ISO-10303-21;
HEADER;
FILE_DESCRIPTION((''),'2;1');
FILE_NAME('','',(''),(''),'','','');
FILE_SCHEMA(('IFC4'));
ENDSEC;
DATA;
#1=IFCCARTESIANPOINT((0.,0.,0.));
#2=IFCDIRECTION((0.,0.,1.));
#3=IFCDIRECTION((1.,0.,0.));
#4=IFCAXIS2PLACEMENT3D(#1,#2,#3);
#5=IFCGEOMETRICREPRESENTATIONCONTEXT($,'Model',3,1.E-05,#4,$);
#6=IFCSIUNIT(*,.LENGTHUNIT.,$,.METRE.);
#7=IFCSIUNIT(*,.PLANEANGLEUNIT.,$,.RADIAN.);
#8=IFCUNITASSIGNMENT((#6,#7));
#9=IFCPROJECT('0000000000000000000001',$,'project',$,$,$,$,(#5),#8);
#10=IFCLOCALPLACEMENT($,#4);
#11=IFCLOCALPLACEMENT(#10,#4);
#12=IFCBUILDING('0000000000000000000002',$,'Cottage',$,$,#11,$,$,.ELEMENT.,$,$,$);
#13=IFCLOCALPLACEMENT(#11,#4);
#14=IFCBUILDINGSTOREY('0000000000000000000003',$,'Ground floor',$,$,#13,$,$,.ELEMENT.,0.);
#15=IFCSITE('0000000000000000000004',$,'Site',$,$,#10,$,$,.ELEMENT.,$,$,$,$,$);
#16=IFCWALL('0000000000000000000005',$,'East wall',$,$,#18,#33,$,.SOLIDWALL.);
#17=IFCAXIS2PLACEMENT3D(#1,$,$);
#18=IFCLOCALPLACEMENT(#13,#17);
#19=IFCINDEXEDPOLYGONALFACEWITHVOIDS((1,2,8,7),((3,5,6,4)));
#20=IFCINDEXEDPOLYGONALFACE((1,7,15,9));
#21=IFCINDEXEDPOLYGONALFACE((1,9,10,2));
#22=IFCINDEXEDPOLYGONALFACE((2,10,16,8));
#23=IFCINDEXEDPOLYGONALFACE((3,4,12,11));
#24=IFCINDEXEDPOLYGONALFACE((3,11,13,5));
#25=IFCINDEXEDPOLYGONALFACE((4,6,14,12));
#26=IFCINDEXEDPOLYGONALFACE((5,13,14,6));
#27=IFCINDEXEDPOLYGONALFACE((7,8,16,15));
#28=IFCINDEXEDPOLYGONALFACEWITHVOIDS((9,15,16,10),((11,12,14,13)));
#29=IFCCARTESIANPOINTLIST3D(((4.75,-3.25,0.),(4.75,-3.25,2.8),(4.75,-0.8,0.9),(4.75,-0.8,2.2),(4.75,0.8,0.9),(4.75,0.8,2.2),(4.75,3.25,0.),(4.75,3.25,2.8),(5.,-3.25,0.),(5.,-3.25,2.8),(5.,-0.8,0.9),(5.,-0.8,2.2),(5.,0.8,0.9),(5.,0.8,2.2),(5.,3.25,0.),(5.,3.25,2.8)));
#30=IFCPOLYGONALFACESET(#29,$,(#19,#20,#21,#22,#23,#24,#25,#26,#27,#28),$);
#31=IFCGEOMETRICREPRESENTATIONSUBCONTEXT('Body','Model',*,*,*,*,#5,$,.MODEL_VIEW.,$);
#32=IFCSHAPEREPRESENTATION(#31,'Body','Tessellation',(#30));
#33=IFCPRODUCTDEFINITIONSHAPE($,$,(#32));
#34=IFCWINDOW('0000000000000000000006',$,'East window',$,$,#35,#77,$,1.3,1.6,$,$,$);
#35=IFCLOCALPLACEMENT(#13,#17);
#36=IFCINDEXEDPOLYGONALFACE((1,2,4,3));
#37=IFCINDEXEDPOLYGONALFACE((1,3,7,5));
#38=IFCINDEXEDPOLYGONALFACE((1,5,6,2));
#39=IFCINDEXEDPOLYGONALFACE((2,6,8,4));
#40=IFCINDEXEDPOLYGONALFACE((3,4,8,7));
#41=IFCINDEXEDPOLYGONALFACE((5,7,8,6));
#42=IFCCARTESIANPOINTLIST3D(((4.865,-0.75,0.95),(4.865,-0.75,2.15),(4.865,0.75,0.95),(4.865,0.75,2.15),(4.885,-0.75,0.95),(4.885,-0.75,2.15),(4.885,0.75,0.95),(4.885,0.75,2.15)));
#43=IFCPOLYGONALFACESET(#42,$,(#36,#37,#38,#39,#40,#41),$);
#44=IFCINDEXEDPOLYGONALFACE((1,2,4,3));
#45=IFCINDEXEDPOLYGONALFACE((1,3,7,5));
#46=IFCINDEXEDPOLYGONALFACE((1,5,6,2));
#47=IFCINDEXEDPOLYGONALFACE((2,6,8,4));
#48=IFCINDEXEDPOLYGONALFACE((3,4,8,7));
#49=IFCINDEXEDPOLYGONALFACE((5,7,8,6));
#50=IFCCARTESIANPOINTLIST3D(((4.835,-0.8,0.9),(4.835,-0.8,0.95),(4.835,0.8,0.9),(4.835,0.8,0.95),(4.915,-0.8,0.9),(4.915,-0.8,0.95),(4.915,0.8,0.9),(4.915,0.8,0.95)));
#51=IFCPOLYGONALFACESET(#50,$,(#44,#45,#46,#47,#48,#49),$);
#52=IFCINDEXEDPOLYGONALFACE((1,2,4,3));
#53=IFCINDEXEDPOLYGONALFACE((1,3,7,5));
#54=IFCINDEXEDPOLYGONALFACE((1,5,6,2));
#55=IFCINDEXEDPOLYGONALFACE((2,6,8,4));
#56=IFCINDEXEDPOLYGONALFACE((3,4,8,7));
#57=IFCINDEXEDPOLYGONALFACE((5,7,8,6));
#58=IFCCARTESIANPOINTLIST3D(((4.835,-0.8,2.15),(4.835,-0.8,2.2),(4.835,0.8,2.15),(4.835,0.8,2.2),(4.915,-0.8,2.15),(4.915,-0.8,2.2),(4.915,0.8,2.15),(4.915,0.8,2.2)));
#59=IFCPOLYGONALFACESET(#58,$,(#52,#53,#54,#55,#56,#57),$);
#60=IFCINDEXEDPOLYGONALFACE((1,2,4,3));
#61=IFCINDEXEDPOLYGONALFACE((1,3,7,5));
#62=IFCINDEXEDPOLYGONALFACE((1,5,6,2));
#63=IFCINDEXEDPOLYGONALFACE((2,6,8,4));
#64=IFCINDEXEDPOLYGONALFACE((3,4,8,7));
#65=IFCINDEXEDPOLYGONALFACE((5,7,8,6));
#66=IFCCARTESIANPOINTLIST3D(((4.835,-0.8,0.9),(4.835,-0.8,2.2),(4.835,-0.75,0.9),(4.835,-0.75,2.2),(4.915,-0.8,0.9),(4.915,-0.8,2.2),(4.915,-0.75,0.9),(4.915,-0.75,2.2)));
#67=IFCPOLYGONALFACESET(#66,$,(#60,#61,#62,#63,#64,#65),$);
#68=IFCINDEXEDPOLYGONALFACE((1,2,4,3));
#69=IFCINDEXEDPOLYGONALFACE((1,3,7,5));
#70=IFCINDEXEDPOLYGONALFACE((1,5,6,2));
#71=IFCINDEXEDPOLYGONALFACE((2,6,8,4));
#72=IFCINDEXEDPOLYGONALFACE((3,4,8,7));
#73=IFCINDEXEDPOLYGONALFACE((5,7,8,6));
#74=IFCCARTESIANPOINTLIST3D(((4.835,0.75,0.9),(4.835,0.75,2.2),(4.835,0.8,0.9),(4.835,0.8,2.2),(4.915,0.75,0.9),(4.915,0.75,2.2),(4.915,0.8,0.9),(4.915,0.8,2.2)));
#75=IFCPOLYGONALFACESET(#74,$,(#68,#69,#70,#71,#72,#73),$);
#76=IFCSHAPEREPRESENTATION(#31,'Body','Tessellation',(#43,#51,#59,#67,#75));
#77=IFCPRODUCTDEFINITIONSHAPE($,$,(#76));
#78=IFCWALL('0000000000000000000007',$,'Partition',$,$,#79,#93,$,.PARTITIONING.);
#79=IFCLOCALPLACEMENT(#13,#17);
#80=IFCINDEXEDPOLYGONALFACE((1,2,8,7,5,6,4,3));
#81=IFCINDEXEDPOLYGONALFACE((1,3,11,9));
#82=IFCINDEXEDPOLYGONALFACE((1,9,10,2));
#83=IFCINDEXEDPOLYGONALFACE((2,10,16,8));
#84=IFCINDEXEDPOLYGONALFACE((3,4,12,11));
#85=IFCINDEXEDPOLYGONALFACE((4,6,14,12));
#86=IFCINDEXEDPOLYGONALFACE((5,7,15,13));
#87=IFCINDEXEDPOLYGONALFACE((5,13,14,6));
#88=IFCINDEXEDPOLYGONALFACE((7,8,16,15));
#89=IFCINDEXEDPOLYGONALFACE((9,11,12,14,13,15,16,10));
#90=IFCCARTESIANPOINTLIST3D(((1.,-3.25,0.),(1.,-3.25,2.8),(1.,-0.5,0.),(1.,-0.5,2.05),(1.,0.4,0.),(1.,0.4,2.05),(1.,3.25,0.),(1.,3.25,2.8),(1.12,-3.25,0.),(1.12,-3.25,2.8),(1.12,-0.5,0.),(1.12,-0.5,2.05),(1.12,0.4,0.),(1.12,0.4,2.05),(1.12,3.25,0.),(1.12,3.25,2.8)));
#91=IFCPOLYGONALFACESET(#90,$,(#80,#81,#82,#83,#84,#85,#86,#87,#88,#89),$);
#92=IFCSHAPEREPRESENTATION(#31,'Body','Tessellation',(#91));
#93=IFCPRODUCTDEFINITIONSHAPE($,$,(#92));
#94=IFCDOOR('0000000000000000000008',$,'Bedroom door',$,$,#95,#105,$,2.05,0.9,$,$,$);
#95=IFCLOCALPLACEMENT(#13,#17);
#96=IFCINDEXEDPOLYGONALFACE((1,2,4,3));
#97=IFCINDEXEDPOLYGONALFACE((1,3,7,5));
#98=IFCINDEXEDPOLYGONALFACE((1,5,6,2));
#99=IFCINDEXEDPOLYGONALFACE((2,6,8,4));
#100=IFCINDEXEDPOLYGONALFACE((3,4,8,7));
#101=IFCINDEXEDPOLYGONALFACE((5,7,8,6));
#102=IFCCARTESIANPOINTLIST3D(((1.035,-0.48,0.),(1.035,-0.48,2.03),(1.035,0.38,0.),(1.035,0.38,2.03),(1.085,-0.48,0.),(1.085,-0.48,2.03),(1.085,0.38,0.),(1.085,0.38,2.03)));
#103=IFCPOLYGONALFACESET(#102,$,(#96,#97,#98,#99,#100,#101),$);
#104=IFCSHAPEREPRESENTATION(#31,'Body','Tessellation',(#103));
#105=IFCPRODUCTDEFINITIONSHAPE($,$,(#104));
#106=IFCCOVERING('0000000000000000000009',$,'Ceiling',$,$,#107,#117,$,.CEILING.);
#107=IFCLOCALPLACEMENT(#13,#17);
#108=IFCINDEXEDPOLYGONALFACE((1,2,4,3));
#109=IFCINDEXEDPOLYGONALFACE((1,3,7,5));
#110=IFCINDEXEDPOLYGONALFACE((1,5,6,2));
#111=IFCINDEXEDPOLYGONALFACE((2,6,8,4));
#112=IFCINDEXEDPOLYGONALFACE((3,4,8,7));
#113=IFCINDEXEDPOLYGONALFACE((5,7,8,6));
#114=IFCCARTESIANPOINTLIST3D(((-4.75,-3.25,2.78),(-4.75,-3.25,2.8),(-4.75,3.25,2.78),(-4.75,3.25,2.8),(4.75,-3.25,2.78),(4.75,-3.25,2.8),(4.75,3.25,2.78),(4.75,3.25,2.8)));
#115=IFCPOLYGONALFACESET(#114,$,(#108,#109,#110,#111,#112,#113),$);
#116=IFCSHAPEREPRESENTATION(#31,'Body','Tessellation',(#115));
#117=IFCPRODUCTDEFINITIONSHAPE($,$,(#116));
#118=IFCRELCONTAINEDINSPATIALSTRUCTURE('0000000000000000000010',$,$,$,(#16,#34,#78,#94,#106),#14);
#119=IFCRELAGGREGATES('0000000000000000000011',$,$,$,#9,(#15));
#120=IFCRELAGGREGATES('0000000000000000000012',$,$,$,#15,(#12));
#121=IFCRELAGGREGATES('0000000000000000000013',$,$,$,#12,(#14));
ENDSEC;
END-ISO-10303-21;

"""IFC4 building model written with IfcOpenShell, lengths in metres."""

from ifc_helpers import new_model, si_unit, frame, frame_2d, origin_with_axes, origin_2d, place, context, subcontext, project, spatial, rectangle, extrude, element, fill, save


model = new_model("IFC4")

# Units and contexts
model_context = context("Model", 3, precision=1e-05, world=origin_with_axes())
body_context = subcontext(model_context, "Body", "Model", "MODEL_VIEW")
ifc_project = project(units=[si_unit("LENGTHUNIT", "METRE"), si_unit("PLANEANGLEUNIT", "RADIAN")], contexts=[model_context])

# Site, building, storey
site_placement = place(None, origin_with_axes())
site = spatial("IfcSite", under=ifc_project, at=site_placement, Name="Site", CompositionType="ELEMENT")
building_placement = place(site_placement, origin_with_axes())
building = spatial("IfcBuilding", under=site, at=building_placement, Name="Cottage", CompositionType="ELEMENT")
storey_placement = place(building_placement, origin_with_axes())
storey = spatial("IfcBuildingStorey", under=building, at=storey_placement, Name="Ground floor", CompositionType="ELEMENT", Elevation=0.0)

# Wall, opening, window
wall_1_placement = place(storey_placement, origin_with_axes())
wall_1 = element("IfcWall", 1, at=wall_1_placement, inside=storey, Name="East wall", PredefinedType="SOLIDWALL", context=body_context, shape_type="SweptSolid", body=[
    extrude(rectangle(XDim=0.25, YDim=6.5, at=frame_2d((4.875, 0.0))), origin_with_axes(), (0.0, 0.0, 1.0), 2.8),
])
opening_1_placement = place(storey_placement, origin_with_axes())
opening_1 = element("IfcOpeningElement", 2, at=opening_1_placement, cuts=wall_1, PredefinedType="OPENING", context=body_context, shape_type="SweptSolid", body=[
    extrude(rectangle(XDim=0.45, YDim=1.6, at=frame_2d((4.875, 0.0))), frame((0.0, 0.0, 0.9), z_axis=(0.0, 0.0, 1.0), x_axis=(1.0, 0.0, 0.0)), (0.0, 0.0, 1.0), 1.3),
])
window_1_placement = place(storey_placement, origin_with_axes())
window_1 = element("IfcWindow", 3, at=window_1_placement, inside=storey, Name="East window", OverallHeight=1.3, OverallWidth=1.6, context=body_context, shape_type="SweptSolid", body=[
    extrude(rectangle(XDim=0.02, YDim=1.5, at=frame_2d((4.875, 0.0))), frame((0.0, 0.0, 0.95), z_axis=(0.0, 0.0, 1.0), x_axis=(1.0, 0.0, 0.0)), (0.0, 0.0, 1.0), 1.2),
    extrude(rectangle(XDim=0.08, YDim=1.6, at=frame_2d((4.875, 0.0))), frame((0.0, 0.0, 0.9), z_axis=(0.0, 0.0, 1.0), x_axis=(1.0, 0.0, 0.0)), (0.0, 0.0, 1.0), 0.05),
    extrude(rectangle(XDim=0.08, YDim=1.6, at=frame_2d((4.875, 0.0))), frame((0.0, 0.0, 2.15), z_axis=(0.0, 0.0, 1.0), x_axis=(1.0, 0.0, 0.0)), (0.0, 0.0, 1.0), 0.05),
    extrude(rectangle(XDim=0.08, YDim=0.05, at=frame_2d((4.875, -0.775))), frame((0.0, 0.0, 0.9), z_axis=(0.0, 0.0, 1.0), x_axis=(1.0, 0.0, 0.0)), (0.0, 0.0, 1.0), 1.3),
    extrude(rectangle(XDim=0.08, YDim=0.05, at=frame_2d((4.875, 0.775))), frame((0.0, 0.0, 0.9), z_axis=(0.0, 0.0, 1.0), x_axis=(1.0, 0.0, 0.0)), (0.0, 0.0, 1.0), 1.3),
])
fill(opening_1, window_1)

# Wall, opening, door
wall_2_placement = place(storey_placement, origin_with_axes())
wall_2 = element("IfcWall", 4, at=wall_2_placement, inside=storey, Name="Partition", PredefinedType="PARTITIONING", context=body_context, shape_type="SweptSolid", body=[
    extrude(rectangle(XDim=0.12, YDim=6.5, at=frame_2d((1.06, 0.0))), origin_with_axes(), (0.0, 0.0, 1.0), 2.8),
])
opening_2_placement = place(storey_placement, origin_with_axes())
opening_2 = element("IfcOpeningElement", 5, at=opening_2_placement, cuts=wall_2, PredefinedType="OPENING", context=body_context, shape_type="SweptSolid", body=[
    extrude(rectangle(XDim=0.22, YDim=0.9, at=frame_2d((1.06, -0.05))), origin_with_axes(), (0.0, 0.0, 1.0), 2.05),
])
door_1_placement = place(storey_placement, origin_with_axes())
door_1 = element("IfcDoor", 6, at=door_1_placement, inside=storey, Name="Bedroom door", OverallHeight=2.05, OverallWidth=0.9, context=body_context, shape_type="SweptSolid", body=[
    extrude(rectangle(XDim=0.05, YDim=0.86, at=frame_2d((1.06, -0.05))), origin_with_axes(), (0.0, 0.0, 1.0), 2.03),
])
fill(opening_2, door_1)

# Covering
covering_placement = place(storey_placement, origin_with_axes())
element("IfcCovering", 7, at=covering_placement, inside=storey, Name="Ceiling", PredefinedType="CEILING", context=body_context, shape_type="SweptSolid", body=[
    extrude(rectangle(XDim=9.5, YDim=6.5, at=origin_2d()), frame((0.0, 0.0, 2.78), z_axis=(0.0, 0.0, 1.0), x_axis=(1.0, 0.0, 0.0)), (0.0, 0.0, 1.0), 0.02),
])

save(model, "model.ifc")
